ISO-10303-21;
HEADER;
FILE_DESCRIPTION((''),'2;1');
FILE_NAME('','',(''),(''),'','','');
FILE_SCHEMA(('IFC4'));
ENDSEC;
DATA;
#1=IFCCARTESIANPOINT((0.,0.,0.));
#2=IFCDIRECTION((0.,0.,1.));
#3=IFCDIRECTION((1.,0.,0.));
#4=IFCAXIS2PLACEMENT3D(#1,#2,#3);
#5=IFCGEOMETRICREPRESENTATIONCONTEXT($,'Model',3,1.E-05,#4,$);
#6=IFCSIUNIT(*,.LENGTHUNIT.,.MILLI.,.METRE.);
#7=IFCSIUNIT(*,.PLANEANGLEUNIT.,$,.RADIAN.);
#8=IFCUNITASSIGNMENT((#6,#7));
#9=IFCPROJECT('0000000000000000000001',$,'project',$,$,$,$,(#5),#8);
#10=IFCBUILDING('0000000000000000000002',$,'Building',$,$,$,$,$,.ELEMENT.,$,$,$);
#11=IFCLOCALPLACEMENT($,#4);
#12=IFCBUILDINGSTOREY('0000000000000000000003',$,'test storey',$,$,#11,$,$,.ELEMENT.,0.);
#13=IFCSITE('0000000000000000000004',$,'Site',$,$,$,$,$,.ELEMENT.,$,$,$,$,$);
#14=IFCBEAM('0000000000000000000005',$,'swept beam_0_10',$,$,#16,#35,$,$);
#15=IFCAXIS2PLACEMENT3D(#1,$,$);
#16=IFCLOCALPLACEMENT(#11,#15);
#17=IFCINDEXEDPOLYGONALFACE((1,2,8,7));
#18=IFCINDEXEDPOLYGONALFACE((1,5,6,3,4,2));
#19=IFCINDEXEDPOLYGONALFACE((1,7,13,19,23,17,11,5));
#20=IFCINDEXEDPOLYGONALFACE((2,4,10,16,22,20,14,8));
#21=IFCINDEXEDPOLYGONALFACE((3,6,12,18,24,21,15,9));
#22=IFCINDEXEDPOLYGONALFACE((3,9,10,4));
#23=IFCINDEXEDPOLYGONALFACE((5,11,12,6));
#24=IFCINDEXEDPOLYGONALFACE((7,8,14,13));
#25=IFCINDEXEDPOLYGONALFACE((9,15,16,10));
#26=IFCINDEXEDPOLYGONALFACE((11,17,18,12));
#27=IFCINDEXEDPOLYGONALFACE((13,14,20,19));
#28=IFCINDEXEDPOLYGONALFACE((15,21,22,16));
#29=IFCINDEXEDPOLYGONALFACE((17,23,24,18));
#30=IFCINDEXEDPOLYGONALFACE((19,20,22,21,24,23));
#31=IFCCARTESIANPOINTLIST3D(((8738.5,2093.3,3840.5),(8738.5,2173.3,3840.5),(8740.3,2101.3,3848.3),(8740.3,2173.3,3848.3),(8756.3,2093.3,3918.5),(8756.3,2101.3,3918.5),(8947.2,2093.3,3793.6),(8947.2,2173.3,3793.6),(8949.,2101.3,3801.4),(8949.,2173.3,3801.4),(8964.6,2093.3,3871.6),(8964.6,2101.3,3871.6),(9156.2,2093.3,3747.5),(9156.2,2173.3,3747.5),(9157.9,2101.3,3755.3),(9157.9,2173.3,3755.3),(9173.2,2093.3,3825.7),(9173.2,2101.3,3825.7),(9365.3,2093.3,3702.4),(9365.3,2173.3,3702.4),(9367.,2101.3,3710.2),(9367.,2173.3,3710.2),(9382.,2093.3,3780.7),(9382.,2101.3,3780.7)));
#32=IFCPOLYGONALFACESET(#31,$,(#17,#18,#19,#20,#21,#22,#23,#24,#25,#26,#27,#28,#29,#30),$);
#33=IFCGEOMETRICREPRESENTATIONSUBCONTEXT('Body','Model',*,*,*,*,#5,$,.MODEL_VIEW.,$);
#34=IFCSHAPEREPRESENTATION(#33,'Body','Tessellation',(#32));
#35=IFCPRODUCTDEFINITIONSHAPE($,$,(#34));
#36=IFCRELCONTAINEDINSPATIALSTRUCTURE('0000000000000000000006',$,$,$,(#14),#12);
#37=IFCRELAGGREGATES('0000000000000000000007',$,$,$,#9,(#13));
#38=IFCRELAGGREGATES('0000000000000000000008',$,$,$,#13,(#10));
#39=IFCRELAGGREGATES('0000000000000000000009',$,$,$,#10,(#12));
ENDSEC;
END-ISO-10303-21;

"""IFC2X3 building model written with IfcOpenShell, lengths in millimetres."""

from ifc_helpers import new_model, entity, si_unit, origin_with_axes, place, context, subcontext, project, spatial, element, save


model = new_model("IFC2X3")

# Units and contexts
model_context = context("Model", 3, precision=1e-05, world=origin_with_axes())
body_context = subcontext(model_context, "Body", "Model", "MODEL_VIEW")
ifc_project = project(units=[si_unit("LENGTHUNIT", "METRE", prefix="MILLI"), si_unit("PLANEANGLEUNIT", "RADIAN")], contexts=[model_context])

# Site, building, storey
site = spatial("IfcSite", under=ifc_project, Name="Site", CompositionType="ELEMENT")
building = spatial("IfcBuilding", under=site, Name="Building", CompositionType="ELEMENT")
storey_placement = place(None, origin_with_axes())
storey = spatial("IfcBuildingStorey", under=building, at=storey_placement, Name="test storey", CompositionType="ELEMENT", Elevation=0.0)

# Beam
beam_1_placement = place(storey_placement, origin_with_axes())
element("IfcBeam", 1, at=beam_1_placement, inside=storey, Name="swept beam_0_10", context=body_context, shape_type="SweptSolid", body=[
    entity("IfcRevolvedAreaSolid", entity("IfcArbitraryClosedProfileDef", "AREA", None, entity("IfcPolyline", [entity("IfcCartesianPoint", [-80.0, 40.0]), entity("IfcCartesianPoint", [-80.0, 32.0]), entity("IfcCartesianPoint", [-8.0, 32.0]), entity("IfcCartesianPoint", [-8.0, -40.0]), entity("IfcCartesianPoint", [0.0, -40.0]), entity("IfcCartesianPoint", [0.0, 40.0]), entity("IfcCartesianPoint", [-80.0, 40.0])])), entity("IfcAxis2Placement3D", entity("IfcCartesianPoint", [8738.5, 2133.3, 3840.5]), entity("IfcDirection", [-0.9751, 0.0, 0.2217]), entity("IfcDirection", [-0.2217, 0.0, -0.9751])), entity("IfcAxis1Placement", entity("IfcCartesianPoint", [-48005.5, 0.0, 0.0]), entity("IfcDirection", [0.0, 1.0, 0.0])), 0.013369),
])

save(model, "model.ifc")
